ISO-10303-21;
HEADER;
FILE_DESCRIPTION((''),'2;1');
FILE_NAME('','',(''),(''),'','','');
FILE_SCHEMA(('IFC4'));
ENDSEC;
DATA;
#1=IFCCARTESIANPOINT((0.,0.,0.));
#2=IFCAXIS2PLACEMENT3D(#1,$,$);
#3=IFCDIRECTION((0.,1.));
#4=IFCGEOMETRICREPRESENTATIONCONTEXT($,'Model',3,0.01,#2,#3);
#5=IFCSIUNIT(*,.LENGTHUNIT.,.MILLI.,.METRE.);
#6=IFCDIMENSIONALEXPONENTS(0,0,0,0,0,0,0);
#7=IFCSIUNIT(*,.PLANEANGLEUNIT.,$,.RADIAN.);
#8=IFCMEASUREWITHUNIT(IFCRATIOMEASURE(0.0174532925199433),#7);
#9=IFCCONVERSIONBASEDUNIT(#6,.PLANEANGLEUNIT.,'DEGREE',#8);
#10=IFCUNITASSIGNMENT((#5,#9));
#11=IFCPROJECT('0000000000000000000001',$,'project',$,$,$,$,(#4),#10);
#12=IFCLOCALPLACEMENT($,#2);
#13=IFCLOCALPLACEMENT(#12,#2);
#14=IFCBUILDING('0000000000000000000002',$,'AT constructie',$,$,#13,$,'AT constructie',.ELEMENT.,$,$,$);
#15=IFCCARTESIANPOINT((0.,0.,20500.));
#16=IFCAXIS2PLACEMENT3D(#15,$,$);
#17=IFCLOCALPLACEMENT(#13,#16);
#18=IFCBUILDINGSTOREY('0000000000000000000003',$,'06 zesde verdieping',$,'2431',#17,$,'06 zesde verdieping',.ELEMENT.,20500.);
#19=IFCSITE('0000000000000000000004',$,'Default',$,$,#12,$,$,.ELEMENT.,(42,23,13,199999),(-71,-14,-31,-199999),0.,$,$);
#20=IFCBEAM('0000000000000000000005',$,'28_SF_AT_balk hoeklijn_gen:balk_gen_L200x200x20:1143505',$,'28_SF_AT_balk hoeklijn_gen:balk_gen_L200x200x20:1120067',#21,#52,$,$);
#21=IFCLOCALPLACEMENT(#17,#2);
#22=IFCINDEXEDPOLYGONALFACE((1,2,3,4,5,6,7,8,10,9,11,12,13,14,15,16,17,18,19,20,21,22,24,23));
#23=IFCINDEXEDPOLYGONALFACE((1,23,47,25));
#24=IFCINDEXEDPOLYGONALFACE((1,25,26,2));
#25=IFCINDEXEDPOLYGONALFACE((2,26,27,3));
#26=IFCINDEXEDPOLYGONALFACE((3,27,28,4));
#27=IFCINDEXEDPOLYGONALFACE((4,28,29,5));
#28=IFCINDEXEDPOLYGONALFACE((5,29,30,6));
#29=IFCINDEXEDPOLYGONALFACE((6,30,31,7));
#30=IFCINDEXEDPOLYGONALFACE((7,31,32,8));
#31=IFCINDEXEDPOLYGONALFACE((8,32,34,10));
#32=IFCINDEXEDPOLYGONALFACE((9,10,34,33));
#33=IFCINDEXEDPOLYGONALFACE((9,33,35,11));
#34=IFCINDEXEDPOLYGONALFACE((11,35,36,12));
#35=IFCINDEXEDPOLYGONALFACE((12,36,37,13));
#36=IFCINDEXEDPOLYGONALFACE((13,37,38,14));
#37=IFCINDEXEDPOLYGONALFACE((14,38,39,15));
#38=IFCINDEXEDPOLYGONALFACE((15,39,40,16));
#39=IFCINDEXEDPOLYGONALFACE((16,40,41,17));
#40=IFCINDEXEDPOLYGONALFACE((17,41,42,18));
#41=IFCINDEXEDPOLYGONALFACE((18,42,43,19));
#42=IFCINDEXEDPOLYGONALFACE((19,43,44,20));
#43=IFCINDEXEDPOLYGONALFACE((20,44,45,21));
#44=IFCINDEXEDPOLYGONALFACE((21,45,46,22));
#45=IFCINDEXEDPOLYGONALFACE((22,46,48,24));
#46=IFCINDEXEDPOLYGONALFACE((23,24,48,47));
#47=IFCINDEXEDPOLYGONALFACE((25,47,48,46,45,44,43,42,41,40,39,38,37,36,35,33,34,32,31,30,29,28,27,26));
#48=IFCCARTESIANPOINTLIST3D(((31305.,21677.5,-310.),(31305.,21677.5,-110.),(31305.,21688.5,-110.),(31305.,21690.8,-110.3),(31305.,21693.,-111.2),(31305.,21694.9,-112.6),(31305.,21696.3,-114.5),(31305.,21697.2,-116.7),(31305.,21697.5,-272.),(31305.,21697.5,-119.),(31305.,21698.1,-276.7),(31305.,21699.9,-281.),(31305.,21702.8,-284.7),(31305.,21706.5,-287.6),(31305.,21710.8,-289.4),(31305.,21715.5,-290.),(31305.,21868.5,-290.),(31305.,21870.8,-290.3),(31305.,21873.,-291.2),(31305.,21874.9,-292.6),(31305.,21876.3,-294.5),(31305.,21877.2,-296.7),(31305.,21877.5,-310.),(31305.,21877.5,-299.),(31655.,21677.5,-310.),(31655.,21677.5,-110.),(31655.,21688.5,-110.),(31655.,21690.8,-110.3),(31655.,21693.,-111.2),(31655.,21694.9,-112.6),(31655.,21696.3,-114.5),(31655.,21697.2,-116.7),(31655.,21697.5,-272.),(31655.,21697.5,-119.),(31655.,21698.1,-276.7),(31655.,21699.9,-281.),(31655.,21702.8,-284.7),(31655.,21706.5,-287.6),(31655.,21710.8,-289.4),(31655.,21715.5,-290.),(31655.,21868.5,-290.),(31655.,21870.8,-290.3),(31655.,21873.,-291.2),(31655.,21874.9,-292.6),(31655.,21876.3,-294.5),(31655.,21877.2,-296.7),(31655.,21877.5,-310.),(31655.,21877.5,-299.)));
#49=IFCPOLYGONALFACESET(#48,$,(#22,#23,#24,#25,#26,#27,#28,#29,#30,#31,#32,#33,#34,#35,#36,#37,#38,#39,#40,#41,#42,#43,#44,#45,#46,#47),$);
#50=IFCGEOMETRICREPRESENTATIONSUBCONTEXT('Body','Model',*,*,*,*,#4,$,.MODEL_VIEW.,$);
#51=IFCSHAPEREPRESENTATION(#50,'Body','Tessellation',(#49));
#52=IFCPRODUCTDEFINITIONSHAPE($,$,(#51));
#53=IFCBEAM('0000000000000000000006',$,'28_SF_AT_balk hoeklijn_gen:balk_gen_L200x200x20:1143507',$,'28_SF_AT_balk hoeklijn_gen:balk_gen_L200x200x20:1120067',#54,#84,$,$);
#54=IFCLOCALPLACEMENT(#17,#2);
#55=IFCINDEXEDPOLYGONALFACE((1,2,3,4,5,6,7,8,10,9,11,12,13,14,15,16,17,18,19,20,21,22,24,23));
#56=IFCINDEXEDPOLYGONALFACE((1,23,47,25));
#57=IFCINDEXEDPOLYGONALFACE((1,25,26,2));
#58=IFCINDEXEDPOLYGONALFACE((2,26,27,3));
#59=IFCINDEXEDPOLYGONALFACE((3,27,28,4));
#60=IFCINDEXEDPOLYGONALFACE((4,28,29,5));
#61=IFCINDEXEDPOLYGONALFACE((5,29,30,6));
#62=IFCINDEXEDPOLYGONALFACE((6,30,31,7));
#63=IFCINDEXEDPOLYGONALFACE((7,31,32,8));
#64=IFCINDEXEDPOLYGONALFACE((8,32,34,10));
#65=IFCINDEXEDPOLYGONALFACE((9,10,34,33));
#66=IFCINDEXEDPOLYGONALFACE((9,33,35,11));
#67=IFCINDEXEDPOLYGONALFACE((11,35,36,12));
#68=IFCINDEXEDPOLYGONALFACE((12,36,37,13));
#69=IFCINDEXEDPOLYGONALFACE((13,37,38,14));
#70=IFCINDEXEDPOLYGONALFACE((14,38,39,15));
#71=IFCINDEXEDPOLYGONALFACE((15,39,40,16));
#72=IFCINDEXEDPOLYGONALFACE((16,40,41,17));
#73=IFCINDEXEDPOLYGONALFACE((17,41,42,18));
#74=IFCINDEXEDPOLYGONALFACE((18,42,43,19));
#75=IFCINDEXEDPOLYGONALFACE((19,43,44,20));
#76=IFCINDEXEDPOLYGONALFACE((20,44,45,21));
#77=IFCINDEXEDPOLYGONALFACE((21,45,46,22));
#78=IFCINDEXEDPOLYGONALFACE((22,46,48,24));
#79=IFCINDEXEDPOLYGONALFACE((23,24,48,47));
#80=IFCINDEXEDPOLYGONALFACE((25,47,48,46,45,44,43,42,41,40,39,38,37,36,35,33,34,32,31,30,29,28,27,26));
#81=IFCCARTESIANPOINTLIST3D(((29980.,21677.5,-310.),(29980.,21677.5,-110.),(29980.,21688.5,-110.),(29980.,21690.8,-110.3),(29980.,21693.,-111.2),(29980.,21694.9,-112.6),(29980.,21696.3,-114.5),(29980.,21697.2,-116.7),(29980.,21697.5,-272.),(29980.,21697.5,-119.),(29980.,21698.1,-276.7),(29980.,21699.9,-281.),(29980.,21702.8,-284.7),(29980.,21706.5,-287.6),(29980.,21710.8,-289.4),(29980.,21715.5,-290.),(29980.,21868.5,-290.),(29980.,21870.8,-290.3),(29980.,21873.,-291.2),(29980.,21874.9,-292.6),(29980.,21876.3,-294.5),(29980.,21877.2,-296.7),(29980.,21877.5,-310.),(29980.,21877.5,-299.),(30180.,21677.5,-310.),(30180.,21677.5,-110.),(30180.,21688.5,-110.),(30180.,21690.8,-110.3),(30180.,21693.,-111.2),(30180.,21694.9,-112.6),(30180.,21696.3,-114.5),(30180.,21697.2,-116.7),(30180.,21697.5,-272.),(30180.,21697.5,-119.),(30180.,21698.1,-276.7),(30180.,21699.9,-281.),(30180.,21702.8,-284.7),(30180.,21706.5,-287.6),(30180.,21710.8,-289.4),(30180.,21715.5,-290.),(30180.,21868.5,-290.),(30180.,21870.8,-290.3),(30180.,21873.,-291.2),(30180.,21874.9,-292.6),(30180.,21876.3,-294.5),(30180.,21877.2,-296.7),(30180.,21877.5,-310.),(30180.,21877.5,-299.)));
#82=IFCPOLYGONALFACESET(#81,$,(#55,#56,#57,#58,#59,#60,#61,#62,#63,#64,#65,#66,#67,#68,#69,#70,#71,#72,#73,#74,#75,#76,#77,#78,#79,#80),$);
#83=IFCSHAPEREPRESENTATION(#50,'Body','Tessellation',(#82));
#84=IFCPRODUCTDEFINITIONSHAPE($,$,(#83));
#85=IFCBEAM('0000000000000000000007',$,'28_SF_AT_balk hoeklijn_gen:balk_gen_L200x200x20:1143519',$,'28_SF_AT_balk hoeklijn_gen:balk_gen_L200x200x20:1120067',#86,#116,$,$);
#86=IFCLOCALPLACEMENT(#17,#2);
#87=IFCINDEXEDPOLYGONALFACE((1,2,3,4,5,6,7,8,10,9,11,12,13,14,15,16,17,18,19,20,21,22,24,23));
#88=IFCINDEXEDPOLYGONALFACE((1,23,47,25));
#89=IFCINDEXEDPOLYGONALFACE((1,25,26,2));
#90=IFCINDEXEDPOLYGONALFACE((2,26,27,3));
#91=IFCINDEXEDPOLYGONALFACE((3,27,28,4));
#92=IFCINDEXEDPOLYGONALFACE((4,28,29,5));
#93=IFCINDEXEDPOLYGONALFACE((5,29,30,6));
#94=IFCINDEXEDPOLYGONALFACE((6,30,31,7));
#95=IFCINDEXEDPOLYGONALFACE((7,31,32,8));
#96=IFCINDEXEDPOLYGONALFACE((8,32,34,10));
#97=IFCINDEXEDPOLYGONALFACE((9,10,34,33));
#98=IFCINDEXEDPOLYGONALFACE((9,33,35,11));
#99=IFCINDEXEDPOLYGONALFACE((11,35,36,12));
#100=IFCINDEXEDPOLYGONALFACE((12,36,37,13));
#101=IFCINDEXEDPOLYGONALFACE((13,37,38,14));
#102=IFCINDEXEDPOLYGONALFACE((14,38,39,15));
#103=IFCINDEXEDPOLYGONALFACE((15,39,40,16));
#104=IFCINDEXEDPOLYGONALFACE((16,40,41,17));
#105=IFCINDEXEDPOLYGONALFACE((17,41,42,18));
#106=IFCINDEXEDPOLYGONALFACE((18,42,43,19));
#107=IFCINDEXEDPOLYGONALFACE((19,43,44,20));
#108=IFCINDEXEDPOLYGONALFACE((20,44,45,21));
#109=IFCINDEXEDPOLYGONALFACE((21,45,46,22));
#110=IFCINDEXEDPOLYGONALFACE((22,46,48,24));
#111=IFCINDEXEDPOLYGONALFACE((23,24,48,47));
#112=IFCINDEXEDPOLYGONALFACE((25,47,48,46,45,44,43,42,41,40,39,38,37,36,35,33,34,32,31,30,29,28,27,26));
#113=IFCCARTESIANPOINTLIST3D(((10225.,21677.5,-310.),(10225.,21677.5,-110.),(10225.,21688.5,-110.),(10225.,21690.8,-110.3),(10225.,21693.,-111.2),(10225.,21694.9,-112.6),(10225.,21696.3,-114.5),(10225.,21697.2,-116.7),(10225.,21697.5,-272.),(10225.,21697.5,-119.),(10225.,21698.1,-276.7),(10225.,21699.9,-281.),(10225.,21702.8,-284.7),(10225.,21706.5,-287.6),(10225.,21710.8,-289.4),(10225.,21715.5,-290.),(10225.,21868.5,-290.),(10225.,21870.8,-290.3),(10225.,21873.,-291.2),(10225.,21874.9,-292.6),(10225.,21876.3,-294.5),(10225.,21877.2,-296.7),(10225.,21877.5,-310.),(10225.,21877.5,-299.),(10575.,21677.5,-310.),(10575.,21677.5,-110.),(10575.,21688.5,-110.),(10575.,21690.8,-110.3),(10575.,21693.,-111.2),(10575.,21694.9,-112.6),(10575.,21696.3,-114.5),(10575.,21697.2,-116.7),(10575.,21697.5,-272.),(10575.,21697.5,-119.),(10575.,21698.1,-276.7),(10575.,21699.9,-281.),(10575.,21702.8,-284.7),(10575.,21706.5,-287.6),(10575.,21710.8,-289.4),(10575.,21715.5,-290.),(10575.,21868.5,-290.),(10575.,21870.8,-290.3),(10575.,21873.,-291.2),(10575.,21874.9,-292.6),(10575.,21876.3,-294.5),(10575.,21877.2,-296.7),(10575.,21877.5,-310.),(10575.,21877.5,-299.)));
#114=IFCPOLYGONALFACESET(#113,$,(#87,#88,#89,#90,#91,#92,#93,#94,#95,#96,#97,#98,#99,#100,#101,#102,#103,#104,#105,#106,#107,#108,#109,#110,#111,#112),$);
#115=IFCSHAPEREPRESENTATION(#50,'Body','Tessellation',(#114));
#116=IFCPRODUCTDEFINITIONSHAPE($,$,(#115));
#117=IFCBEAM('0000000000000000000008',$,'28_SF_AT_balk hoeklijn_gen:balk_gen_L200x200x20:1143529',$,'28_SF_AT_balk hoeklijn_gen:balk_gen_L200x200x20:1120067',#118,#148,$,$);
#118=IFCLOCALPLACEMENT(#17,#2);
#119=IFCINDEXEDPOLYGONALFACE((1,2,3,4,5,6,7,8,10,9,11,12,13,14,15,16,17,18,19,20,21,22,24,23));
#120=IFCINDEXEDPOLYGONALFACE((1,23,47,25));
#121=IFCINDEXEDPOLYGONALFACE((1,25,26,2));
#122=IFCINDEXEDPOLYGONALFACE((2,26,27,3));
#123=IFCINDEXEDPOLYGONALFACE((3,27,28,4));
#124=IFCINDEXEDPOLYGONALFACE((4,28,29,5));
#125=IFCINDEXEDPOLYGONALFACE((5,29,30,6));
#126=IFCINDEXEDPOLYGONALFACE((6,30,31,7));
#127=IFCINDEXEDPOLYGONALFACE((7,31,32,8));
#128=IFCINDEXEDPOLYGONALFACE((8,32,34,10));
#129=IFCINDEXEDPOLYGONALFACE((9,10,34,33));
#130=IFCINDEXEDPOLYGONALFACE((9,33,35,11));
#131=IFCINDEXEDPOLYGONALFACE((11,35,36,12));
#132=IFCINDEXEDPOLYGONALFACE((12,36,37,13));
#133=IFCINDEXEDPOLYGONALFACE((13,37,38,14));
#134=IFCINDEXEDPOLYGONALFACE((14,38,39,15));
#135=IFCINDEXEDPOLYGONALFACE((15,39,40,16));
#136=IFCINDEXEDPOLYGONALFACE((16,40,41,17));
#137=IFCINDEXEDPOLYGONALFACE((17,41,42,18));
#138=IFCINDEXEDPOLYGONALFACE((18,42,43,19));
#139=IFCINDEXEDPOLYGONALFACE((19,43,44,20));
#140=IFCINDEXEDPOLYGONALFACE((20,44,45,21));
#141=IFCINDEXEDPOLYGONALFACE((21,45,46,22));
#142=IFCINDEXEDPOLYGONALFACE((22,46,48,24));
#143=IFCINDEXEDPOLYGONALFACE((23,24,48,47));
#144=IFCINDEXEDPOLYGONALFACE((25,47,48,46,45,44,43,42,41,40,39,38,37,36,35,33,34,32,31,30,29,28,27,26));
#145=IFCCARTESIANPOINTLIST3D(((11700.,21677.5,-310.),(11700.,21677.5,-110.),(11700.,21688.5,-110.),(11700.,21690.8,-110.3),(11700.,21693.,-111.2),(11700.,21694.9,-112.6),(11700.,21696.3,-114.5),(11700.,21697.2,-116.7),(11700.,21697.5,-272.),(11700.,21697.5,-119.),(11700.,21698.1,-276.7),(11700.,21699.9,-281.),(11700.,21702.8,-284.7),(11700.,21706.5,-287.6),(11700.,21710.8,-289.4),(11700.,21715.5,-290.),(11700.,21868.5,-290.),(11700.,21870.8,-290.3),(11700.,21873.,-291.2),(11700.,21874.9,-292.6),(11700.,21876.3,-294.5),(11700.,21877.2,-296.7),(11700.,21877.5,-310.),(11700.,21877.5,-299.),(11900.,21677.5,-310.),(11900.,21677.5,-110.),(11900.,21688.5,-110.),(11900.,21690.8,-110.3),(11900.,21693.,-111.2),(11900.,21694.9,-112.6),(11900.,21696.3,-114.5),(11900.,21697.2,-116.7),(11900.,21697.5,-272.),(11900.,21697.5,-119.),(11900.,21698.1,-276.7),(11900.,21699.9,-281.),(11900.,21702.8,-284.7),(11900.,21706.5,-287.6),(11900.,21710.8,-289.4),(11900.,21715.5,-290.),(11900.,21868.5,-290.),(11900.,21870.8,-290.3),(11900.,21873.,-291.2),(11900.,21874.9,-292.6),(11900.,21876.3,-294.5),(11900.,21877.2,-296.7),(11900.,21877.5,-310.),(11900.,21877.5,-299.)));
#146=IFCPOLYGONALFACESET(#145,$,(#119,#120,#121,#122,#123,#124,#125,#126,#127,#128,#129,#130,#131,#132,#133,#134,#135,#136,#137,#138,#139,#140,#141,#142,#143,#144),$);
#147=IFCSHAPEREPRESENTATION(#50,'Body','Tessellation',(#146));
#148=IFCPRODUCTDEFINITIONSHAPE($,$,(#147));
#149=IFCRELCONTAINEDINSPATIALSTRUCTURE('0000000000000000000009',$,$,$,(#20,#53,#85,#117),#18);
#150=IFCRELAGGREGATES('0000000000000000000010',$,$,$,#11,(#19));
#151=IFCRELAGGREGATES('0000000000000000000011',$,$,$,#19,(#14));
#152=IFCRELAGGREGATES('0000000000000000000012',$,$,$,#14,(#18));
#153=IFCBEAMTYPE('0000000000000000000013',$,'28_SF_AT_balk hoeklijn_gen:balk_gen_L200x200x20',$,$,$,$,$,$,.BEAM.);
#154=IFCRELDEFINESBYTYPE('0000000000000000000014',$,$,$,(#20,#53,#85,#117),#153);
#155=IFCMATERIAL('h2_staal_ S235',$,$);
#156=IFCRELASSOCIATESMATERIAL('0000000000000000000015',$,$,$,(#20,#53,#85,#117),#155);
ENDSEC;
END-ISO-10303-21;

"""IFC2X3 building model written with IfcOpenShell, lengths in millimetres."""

from ifc_helpers import new_model, entity, si_unit, converted_unit, direction, frame, frame_2d, origin, place, context, subcontext, project, spatial, polyline, circle_curve, parameter, trimmed, segment, composite_curve, outline, extrude, material, type_object, element, save


model = new_model("IFC2X3")

# Units and contexts
model_context = context("Model", 3, precision=0.01, world=origin(), true_north=direction((0.0, 1.0)))
body_context = subcontext(model_context, "Body", "Model", "MODEL_VIEW")
ifc_project = project(units=[si_unit("LENGTHUNIT", "METRE", prefix="MILLI"), converted_unit("PLANEANGLEUNIT", "DEGREE", entity("IfcRatioMeasure", 0.0174532925199433), si_unit("PLANEANGLEUNIT", "RADIAN"), dimensions=[0, 0, 0, 0, 0, 0, 0])], contexts=[model_context])

# Site, building, storey
site_placement = place(None, origin())
site = spatial("IfcSite", under=ifc_project, at=site_placement, Name="Default", CompositionType="ELEMENT", RefLatitude=(42, 23, 13, 199999), RefLongitude=(-71, -14, -31, -199999), RefElevation=0.0)
building_placement = place(site_placement, origin())
building = spatial("IfcBuilding", under=site, at=building_placement, Name="AT constructie", LongName="AT constructie", CompositionType="ELEMENT")
storey_placement = place(building_placement, frame((0.0, 0.0, 20500.0)))
storey = spatial("IfcBuildingStorey", under=building, at=storey_placement, Name="06 zesde verdieping", ObjectType="2431", LongName="06 zesde verdieping", CompositionType="ELEMENT", Elevation=20500.0)

# Beams
ifc_material_1 = material(Name="h2_staal_ S235")
beam_type_1 = type_object("IfcBeamType", Name="28_SF_AT_balk hoeklijn_gen:balk_gen_L200x200x20", PredefinedType="BEAM")
beam_1_placement = place(storey_placement, frame((31305.0, 21677.5, -70.0)))
element("IfcBeam", 1, at=beam_1_placement, inside=storey, type_object=beam_type_1, material=ifc_material_1, Name="28_SF_AT_balk hoeklijn_gen:balk_gen_L200x200x20:1143505", ObjectType="28_SF_AT_balk hoeklijn_gen:balk_gen_L200x200x20:1120067", context=body_context, shape_type="SweptSolid", body=[
    extrude(outline(composite_curve([segment(polyline([(-124.4, -75.6), (75.6, -75.6)]), True, "CONTINUOUS"), segment(polyline([(75.6, -75.6), (75.6, 124.4)]), True, "CONTINUOUS"), segment(polyline([(75.6, 124.4), (64.6, 124.4)]), True, "CONTINUOUS"), segment(trimmed(circle_curve(frame_2d((64.6, 115.4), x_axis=(0.0, 1.0)), 9.0), [parameter(0.0)], [parameter(90.0)], True, "PARAMETER"), True, "CONTINUOUS"), segment(polyline([(55.6, 115.4), (55.6, -37.6)]), True, "CONTINUOUS"), segment(trimmed(circle_curve(frame_2d((37.6, -37.6), x_axis=(1.0, 0.0)), 18.0), [parameter(270.0)], [parameter(0.0)], True, "PARAMETER"), False, "CONTINUOUS"), segment(polyline([(37.6, -55.6), (-115.4, -55.6)]), True, "CONTINUOUS"), segment(trimmed(circle_curve(frame_2d((-115.4, -64.6), x_axis=(0.0, 1.0)), 9.0), [parameter(0.0)], [parameter(90.0)], True, "PARAMETER"), True, "CONTINUOUS"), segment(polyline([(-124.4, -64.6), (-124.4, -75.6)]), True, "CONTINUOUS")], self_intersect=False)), frame((0.0, 75.6, -164.4), z_axis=(1.0, 0.0, 0.0), x_axis=(0.0, 0.0, -1.0)), (0.0, 0.0, 1.0), 350.0),
])
beam_2_placement = place(storey_placement, frame((29980.0, 21677.5, -70.0)))
element("IfcBeam", 2, at=beam_2_placement, inside=storey, type_object=beam_type_1, material=ifc_material_1, Name="28_SF_AT_balk hoeklijn_gen:balk_gen_L200x200x20:1143507", ObjectType="28_SF_AT_balk hoeklijn_gen:balk_gen_L200x200x20:1120067", context=body_context, shape_type="SweptSolid", body=[
    extrude(outline(composite_curve([segment(polyline([(-124.4, -75.6), (75.6, -75.6)]), True, "CONTINUOUS"), segment(polyline([(75.6, -75.6), (75.6, 124.4)]), True, "CONTINUOUS"), segment(polyline([(75.6, 124.4), (64.6, 124.4)]), True, "CONTINUOUS"), segment(trimmed(circle_curve(frame_2d((64.6, 115.4), x_axis=(0.0, 1.0)), 9.0), [parameter(0.0)], [parameter(90.0)], True, "PARAMETER"), True, "CONTINUOUS"), segment(polyline([(55.6, 115.4), (55.6, -37.6)]), True, "CONTINUOUS"), segment(trimmed(circle_curve(frame_2d((37.6, -37.6), x_axis=(1.0, 0.0)), 18.0), [parameter(270.0)], [parameter(0.0)], True, "PARAMETER"), False, "CONTINUOUS"), segment(polyline([(37.6, -55.6), (-115.4, -55.6)]), True, "CONTINUOUS"), segment(trimmed(circle_curve(frame_2d((-115.4, -64.6), x_axis=(0.0, 1.0)), 9.0), [parameter(0.0)], [parameter(90.0)], True, "PARAMETER"), True, "CONTINUOUS"), segment(polyline([(-124.4, -64.6), (-124.4, -75.6)]), True, "CONTINUOUS")], self_intersect=False)), frame((0.0, 75.6, -164.4), z_axis=(1.0, 0.0, 0.0), x_axis=(0.0, 0.0, -1.0)), (0.0, 0.0, 1.0), 200.0),
])
beam_3_placement = place(storey_placement, frame((10225.0, 21677.5, -70.0)))
element("IfcBeam", 3, at=beam_3_placement, inside=storey, type_object=beam_type_1, material=ifc_material_1, Name="28_SF_AT_balk hoeklijn_gen:balk_gen_L200x200x20:1143519", ObjectType="28_SF_AT_balk hoeklijn_gen:balk_gen_L200x200x20:1120067", context=body_context, shape_type="SweptSolid", body=[
    extrude(outline(composite_curve([segment(polyline([(-124.4, -75.6), (75.6, -75.6)]), True, "CONTINUOUS"), segment(polyline([(75.6, -75.6), (75.6, 124.4)]), True, "CONTINUOUS"), segment(polyline([(75.6, 124.4), (64.6, 124.4)]), True, "CONTINUOUS"), segment(trimmed(circle_curve(frame_2d((64.6, 115.4), x_axis=(0.0, 1.0)), 9.0), [parameter(0.0)], [parameter(90.0)], True, "PARAMETER"), True, "CONTINUOUS"), segment(polyline([(55.6, 115.4), (55.6, -37.6)]), True, "CONTINUOUS"), segment(trimmed(circle_curve(frame_2d((37.6, -37.6), x_axis=(1.0, 0.0)), 18.0), [parameter(270.0)], [parameter(0.0)], True, "PARAMETER"), False, "CONTINUOUS"), segment(polyline([(37.6, -55.6), (-115.4, -55.6)]), True, "CONTINUOUS"), segment(trimmed(circle_curve(frame_2d((-115.4, -64.6), x_axis=(0.0, 1.0)), 9.0), [parameter(0.0)], [parameter(90.0)], True, "PARAMETER"), True, "CONTINUOUS"), segment(polyline([(-124.4, -64.6), (-124.4, -75.6)]), True, "CONTINUOUS")], self_intersect=False)), frame((0.0, 75.6, -164.4), z_axis=(1.0, 0.0, 0.0), x_axis=(0.0, 0.0, -1.0)), (0.0, 0.0, 1.0), 350.0),
])
beam_4_placement = place(storey_placement, frame((11700.0, 21677.5, -70.0)))
element("IfcBeam", 4, at=beam_4_placement, inside=storey, type_object=beam_type_1, material=ifc_material_1, Name="28_SF_AT_balk hoeklijn_gen:balk_gen_L200x200x20:1143529", ObjectType="28_SF_AT_balk hoeklijn_gen:balk_gen_L200x200x20:1120067", context=body_context, shape_type="SweptSolid", body=[
    extrude(outline(composite_curve([segment(polyline([(-124.4, -75.6), (75.6, -75.6)]), True, "CONTINUOUS"), segment(polyline([(75.6, -75.6), (75.6, 124.4)]), True, "CONTINUOUS"), segment(polyline([(75.6, 124.4), (64.6, 124.4)]), True, "CONTINUOUS"), segment(trimmed(circle_curve(frame_2d((64.6, 115.4), x_axis=(0.0, 1.0)), 9.0), [parameter(0.0)], [parameter(90.0)], True, "PARAMETER"), True, "CONTINUOUS"), segment(polyline([(55.6, 115.4), (55.6, -37.6)]), True, "CONTINUOUS"), segment(trimmed(circle_curve(frame_2d((37.6, -37.6), x_axis=(1.0, 0.0)), 18.0), [parameter(270.0)], [parameter(0.0)], True, "PARAMETER"), False, "CONTINUOUS"), segment(polyline([(37.6, -55.6), (-115.4, -55.6)]), True, "CONTINUOUS"), segment(trimmed(circle_curve(frame_2d((-115.4, -64.6), x_axis=(0.0, 1.0)), 9.0), [parameter(0.0)], [parameter(90.0)], True, "PARAMETER"), True, "CONTINUOUS"), segment(polyline([(-124.4, -64.6), (-124.4, -75.6)]), True, "CONTINUOUS")], self_intersect=False)), frame((0.0, 75.6, -164.4), z_axis=(1.0, 0.0, 0.0), x_axis=(0.0, 0.0, -1.0)), (0.0, 0.0, 1.0), 200.0),
])

save(model, "model.ifc")
